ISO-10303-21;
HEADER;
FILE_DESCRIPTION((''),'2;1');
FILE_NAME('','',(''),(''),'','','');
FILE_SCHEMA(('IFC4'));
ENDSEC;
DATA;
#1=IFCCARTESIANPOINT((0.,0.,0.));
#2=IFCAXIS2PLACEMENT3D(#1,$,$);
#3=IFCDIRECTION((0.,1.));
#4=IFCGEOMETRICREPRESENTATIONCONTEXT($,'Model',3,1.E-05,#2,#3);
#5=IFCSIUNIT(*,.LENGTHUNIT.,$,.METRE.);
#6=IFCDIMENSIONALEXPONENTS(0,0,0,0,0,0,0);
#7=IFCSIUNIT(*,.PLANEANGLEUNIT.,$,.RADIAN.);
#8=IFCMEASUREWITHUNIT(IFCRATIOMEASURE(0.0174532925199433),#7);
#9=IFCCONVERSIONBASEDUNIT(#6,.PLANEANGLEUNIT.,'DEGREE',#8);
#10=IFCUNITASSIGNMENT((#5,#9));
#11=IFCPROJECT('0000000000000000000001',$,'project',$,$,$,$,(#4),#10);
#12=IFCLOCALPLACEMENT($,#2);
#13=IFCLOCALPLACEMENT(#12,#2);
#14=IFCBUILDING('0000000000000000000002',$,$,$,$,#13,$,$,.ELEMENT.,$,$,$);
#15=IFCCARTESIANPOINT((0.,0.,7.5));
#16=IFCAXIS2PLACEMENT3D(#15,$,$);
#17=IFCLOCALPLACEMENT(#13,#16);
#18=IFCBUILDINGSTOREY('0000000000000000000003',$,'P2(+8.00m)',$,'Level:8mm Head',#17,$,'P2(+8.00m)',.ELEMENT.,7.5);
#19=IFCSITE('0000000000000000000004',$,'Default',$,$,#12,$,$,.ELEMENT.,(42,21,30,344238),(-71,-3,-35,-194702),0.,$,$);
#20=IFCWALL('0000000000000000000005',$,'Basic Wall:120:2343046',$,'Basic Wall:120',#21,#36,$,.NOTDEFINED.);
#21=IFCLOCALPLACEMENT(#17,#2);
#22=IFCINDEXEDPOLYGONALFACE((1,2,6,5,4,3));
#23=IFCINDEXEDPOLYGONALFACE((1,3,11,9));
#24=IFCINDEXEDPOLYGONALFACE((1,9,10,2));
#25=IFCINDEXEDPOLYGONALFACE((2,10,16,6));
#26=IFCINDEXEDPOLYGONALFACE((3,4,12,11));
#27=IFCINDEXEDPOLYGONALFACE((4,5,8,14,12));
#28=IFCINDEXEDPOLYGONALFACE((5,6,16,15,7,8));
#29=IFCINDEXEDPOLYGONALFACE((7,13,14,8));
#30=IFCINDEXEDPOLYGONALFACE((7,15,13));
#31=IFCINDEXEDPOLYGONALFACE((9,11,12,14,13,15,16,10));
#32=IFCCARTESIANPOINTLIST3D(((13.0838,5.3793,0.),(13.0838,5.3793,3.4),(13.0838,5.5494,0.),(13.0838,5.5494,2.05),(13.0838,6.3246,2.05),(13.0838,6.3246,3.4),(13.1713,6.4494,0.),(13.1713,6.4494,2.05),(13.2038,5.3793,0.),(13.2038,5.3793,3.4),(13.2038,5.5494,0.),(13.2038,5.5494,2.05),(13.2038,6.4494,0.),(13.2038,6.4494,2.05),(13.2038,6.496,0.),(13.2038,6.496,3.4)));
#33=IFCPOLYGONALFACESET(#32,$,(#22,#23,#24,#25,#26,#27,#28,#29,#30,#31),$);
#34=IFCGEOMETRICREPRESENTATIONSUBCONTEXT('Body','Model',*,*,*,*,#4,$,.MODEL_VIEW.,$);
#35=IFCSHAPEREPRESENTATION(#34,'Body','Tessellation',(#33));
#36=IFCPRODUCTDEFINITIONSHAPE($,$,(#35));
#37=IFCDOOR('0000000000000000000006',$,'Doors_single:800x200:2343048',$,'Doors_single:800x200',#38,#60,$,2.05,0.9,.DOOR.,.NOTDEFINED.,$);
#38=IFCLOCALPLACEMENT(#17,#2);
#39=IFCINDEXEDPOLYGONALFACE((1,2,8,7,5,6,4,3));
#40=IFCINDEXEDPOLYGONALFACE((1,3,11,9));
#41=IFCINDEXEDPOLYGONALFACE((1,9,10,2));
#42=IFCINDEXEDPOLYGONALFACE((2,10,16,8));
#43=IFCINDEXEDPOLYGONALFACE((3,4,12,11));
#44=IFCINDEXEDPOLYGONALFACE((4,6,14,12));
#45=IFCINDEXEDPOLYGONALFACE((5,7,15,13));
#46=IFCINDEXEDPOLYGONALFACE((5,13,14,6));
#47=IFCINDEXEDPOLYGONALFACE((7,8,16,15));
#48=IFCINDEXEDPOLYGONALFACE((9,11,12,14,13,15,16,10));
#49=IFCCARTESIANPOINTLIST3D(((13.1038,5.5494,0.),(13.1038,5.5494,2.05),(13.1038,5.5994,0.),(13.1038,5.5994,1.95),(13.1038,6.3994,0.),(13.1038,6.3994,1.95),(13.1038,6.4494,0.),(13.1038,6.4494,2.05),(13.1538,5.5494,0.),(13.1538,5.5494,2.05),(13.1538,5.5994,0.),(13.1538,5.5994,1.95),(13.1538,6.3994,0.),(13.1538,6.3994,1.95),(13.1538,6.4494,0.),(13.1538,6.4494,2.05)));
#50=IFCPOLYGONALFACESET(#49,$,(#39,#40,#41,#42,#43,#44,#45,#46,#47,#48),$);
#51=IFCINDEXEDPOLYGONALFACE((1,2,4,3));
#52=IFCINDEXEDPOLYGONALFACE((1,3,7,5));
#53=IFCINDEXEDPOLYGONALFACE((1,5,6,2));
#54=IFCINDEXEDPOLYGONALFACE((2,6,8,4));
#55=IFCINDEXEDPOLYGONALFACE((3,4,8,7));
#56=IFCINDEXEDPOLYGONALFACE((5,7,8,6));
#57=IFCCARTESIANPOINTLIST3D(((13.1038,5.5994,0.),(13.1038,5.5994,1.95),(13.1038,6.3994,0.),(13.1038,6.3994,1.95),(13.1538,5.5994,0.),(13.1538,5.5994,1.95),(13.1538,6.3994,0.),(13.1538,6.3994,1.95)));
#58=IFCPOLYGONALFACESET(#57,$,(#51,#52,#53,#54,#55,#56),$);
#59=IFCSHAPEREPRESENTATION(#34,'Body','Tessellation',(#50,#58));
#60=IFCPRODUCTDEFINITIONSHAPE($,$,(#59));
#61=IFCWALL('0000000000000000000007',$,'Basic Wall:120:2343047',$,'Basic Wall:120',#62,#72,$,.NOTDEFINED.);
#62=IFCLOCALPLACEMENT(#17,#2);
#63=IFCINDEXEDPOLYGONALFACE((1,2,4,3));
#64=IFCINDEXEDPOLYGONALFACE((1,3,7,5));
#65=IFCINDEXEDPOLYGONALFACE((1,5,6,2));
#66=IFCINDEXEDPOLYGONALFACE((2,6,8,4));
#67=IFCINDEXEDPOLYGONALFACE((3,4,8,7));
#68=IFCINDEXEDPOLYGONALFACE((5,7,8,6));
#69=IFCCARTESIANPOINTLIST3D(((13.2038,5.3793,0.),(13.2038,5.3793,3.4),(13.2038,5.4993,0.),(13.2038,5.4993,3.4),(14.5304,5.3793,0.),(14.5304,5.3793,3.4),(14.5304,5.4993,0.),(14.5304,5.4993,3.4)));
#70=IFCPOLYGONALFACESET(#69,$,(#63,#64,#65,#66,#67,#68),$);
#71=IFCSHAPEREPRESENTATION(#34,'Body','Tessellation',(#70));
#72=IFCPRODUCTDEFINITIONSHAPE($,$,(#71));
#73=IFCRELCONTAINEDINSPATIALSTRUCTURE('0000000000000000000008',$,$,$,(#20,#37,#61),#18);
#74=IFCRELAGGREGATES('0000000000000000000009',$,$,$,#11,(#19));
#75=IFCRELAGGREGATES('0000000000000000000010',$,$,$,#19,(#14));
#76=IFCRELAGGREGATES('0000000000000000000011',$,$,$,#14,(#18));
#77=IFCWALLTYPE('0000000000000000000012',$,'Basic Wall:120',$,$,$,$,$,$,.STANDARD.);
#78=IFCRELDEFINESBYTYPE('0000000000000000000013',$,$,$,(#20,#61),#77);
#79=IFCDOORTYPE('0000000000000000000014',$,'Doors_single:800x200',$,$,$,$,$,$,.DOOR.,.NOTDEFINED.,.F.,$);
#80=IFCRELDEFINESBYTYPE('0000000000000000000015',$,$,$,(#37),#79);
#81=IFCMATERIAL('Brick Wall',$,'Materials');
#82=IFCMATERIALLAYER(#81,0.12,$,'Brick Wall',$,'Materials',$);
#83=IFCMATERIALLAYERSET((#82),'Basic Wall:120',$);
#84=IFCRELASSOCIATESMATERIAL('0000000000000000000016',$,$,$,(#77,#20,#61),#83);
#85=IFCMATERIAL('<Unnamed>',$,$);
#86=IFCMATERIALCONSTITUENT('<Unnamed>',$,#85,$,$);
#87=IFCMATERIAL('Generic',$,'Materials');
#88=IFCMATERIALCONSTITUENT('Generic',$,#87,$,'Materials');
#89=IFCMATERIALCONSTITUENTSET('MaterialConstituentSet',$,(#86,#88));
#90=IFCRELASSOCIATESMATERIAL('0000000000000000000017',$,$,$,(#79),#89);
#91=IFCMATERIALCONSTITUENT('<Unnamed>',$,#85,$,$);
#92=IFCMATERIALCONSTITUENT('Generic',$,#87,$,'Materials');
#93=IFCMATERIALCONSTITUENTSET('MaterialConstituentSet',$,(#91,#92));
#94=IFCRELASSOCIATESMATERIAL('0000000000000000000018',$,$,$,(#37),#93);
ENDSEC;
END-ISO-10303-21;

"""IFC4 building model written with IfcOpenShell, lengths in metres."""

from ifc_helpers import new_model, entity, si_unit, converted_unit, direction, frame, frame_2d, origin, origin_2d_with_axis, place, context, subcontext, project, spatial, polyline, rectangle, outline, extrude, source, transform, mapped, material, layer, layer_set, layer_usage, constituent, constituent_set, type_object, type_shapes, element, fill, save


model = new_model("IFC4")

# Units and contexts
model_context = context("Model", 3, precision=1e-05, world=origin(), true_north=direction((0.0, 1.0)))
body_context = subcontext(model_context, "Body", "Model", "MODEL_VIEW")
ifc_project = project(units=[si_unit("LENGTHUNIT", "METRE"), converted_unit("PLANEANGLEUNIT", "DEGREE", entity("IfcRatioMeasure", 0.0174532925199433), si_unit("PLANEANGLEUNIT", "RADIAN"), dimensions=[0, 0, 0, 0, 0, 0, 0])], contexts=[model_context])

# Site, building, storey
site_placement = place(None, origin())
site = spatial("IfcSite", under=ifc_project, at=site_placement, Name="Default", CompositionType="ELEMENT", RefLatitude=(42, 21, 30, 344238), RefLongitude=(-71, -3, -35, -194702), RefElevation=0.0)
building_placement = place(site_placement, origin())
building = spatial("IfcBuilding", under=site, at=building_placement, CompositionType="ELEMENT")
storey_placement = place(building_placement, frame((0.0, 0.0, 7.5)))
storey = spatial("IfcBuildingStorey", under=building, at=storey_placement, Name="P2(+8.00m)", ObjectType="Level:8mm Head", LongName="P2(+8.00m)", CompositionType="ELEMENT", Elevation=7.5)

# Shared definitions
ifc_material_1 = material(Name="Brick Wall", Category="Materials")

# Shared definitions
ifc_material_2 = material(Name="<Unnamed>")
ifc_material_3 = material(Name="Generic", Category="Materials")

# Shared definitions
ifc_layer_1 = layer(ifc_material_1, 0.12, Name="Brick Wall", Category="Materials")
ifc_layer_set_1 = layer_set([ifc_layer_1], Name="Basic Wall:120")
wall_type_1 = type_object("IfcWallType", Name="Basic Wall:120", PredefinedType="STANDARD", material=ifc_layer_set_1)

# Wall, opening, door
ifc_layer_usage_1 = layer_usage(ifc_layer_set_1, "AXIS2", "POSITIVE", -0.06)
wall_1_placement = place(storey_placement, frame((13.1438, 6.496, 0.0), z_axis=(0.0, 0.0, 1.0), x_axis=(0.0, -1.0, 0.0)))
wall_1 = element("IfcWall", 1, at=wall_1_placement, inside=storey, type_object=wall_type_1, material=ifc_layer_usage_1, Name="Basic Wall:120:2343046", ObjectType="Basic Wall:120", PredefinedType="NOTDEFINED", context=body_context, shape_type="SweptSolid", body=[
    extrude(outline(polyline([(0.1714, -0.06), (1.1167, -0.06), (1.1167, 0.06), (0.9967, 0.06), (0.0, 0.06), (0.1714, -0.06)])), origin(), (0.0, 0.0, 1.0), 3.4),
])
opening_1_placement = place(wall_1_placement, frame((0.9465, 0.06, 0.0)))
opening_1 = element("IfcOpeningElement", 2, at=opening_1_placement, cuts=wall_1, PredefinedType="OPENING", context=body_context, shape_type="SweptSolid", body=[
    extrude(rectangle(XDim=2.05, YDim=0.9, at=frame_2d((1.025, 0.45), x_axis=(1.0, 0.0))), frame((0.0, 0.0, 0.0), z_axis=(0.0, -1.0, 0.0), x_axis=(0.0, 0.0, 1.0)), (0.0, 0.0, 1.0), 0.12),
])
ifc_constituent_1 = constituent(ifc_material_2, Name="<Unnamed>")
ifc_constituent_2 = constituent(ifc_material_3, Name="Generic", Category="Materials")
ifc_constituent_set_1 = constituent_set(constituents=[ifc_constituent_1, ifc_constituent_2], Name="MaterialConstituentSet")
ifc_constituent_3 = constituent(ifc_material_2, Name="<Unnamed>")
ifc_constituent_4 = constituent(ifc_material_3, Name="Generic", Category="Materials")
ifc_constituent_set_2 = constituent_set(constituents=[ifc_constituent_3, ifc_constituent_4], Name="MaterialConstituentSet")
door_type_1 = type_object("IfcDoorType", Name="Doors_single:800x200", OperationType="NOTDEFINED", ParameterTakesPrecedence=False, PredefinedType="DOOR", material=ifc_constituent_set_2)
shared_shape_1 = source(origin(), body_context, "Body", "SweptSolid", [
    extrude(outline(polyline([(-0.45, -1.0), (-0.4, -1.0), (-0.4, 0.95), (0.4, 0.95), (0.4, -1.0), (0.45, -1.0), (0.45, 1.05), (-0.45, 1.05), (-0.45, -1.0)])), frame((0.45, 0.05, 1.0), z_axis=(0.0, 1.0, 0.0), x_axis=(-1.0, 0.0, 0.0)), (0.0, 0.0, 1.0), 0.05),
    extrude(rectangle(XDim=0.8, YDim=0.05, at=origin_2d_with_axis()), frame((0.45, 0.075, 0.0), z_axis=(0.0, 0.0, 1.0), x_axis=(-1.0, 0.0, 0.0)), (0.0, 0.0, 1.0), 1.95),
])
type_shapes(door_type_1, [shared_shape_1])
door_1_placement = place(opening_1_placement, frame((0.0, 0.0, 0.0), z_axis=(0.0, 0.0, 1.0), x_axis=(-1.0, 0.0, 0.0)))
door_1 = element("IfcDoor", 3, at=door_1_placement, inside=storey, type_object=door_type_1, material=ifc_constituent_set_1, Name="Doors_single:800x200:2343048", ObjectType="Doors_single:800x200", OperationType="NOTDEFINED", OverallHeight=2.05, OverallWidth=0.9, PredefinedType="DOOR", context=body_context, shape_type="MappedRepresentation", body=[
    mapped(shared_shape_1, transform((0.0, 0.0, 0.0), scale=1.0)),
])
fill(opening_1, door_1)

# Wall
ifc_layer_usage_2 = layer_usage(ifc_layer_set_1, "AXIS2", "NEGATIVE", 0.06)
wall_2_placement = place(storey_placement, frame((13.2038, 5.4393, 0.0)))
element("IfcWall", 4, at=wall_2_placement, inside=storey, type_object=wall_type_1, material=ifc_layer_usage_2, Name="Basic Wall:120:2343047", ObjectType="Basic Wall:120", PredefinedType="NOTDEFINED", context=body_context, shape_type="SweptSolid", body=[
    extrude(rectangle(XDim=1.3266, YDim=0.12, at=frame_2d((0.6633, 0.0), x_axis=(-1.0, 0.0))), origin(), (0.0, 0.0, 1.0), 3.4),
])

save(model, "model.ifc")
